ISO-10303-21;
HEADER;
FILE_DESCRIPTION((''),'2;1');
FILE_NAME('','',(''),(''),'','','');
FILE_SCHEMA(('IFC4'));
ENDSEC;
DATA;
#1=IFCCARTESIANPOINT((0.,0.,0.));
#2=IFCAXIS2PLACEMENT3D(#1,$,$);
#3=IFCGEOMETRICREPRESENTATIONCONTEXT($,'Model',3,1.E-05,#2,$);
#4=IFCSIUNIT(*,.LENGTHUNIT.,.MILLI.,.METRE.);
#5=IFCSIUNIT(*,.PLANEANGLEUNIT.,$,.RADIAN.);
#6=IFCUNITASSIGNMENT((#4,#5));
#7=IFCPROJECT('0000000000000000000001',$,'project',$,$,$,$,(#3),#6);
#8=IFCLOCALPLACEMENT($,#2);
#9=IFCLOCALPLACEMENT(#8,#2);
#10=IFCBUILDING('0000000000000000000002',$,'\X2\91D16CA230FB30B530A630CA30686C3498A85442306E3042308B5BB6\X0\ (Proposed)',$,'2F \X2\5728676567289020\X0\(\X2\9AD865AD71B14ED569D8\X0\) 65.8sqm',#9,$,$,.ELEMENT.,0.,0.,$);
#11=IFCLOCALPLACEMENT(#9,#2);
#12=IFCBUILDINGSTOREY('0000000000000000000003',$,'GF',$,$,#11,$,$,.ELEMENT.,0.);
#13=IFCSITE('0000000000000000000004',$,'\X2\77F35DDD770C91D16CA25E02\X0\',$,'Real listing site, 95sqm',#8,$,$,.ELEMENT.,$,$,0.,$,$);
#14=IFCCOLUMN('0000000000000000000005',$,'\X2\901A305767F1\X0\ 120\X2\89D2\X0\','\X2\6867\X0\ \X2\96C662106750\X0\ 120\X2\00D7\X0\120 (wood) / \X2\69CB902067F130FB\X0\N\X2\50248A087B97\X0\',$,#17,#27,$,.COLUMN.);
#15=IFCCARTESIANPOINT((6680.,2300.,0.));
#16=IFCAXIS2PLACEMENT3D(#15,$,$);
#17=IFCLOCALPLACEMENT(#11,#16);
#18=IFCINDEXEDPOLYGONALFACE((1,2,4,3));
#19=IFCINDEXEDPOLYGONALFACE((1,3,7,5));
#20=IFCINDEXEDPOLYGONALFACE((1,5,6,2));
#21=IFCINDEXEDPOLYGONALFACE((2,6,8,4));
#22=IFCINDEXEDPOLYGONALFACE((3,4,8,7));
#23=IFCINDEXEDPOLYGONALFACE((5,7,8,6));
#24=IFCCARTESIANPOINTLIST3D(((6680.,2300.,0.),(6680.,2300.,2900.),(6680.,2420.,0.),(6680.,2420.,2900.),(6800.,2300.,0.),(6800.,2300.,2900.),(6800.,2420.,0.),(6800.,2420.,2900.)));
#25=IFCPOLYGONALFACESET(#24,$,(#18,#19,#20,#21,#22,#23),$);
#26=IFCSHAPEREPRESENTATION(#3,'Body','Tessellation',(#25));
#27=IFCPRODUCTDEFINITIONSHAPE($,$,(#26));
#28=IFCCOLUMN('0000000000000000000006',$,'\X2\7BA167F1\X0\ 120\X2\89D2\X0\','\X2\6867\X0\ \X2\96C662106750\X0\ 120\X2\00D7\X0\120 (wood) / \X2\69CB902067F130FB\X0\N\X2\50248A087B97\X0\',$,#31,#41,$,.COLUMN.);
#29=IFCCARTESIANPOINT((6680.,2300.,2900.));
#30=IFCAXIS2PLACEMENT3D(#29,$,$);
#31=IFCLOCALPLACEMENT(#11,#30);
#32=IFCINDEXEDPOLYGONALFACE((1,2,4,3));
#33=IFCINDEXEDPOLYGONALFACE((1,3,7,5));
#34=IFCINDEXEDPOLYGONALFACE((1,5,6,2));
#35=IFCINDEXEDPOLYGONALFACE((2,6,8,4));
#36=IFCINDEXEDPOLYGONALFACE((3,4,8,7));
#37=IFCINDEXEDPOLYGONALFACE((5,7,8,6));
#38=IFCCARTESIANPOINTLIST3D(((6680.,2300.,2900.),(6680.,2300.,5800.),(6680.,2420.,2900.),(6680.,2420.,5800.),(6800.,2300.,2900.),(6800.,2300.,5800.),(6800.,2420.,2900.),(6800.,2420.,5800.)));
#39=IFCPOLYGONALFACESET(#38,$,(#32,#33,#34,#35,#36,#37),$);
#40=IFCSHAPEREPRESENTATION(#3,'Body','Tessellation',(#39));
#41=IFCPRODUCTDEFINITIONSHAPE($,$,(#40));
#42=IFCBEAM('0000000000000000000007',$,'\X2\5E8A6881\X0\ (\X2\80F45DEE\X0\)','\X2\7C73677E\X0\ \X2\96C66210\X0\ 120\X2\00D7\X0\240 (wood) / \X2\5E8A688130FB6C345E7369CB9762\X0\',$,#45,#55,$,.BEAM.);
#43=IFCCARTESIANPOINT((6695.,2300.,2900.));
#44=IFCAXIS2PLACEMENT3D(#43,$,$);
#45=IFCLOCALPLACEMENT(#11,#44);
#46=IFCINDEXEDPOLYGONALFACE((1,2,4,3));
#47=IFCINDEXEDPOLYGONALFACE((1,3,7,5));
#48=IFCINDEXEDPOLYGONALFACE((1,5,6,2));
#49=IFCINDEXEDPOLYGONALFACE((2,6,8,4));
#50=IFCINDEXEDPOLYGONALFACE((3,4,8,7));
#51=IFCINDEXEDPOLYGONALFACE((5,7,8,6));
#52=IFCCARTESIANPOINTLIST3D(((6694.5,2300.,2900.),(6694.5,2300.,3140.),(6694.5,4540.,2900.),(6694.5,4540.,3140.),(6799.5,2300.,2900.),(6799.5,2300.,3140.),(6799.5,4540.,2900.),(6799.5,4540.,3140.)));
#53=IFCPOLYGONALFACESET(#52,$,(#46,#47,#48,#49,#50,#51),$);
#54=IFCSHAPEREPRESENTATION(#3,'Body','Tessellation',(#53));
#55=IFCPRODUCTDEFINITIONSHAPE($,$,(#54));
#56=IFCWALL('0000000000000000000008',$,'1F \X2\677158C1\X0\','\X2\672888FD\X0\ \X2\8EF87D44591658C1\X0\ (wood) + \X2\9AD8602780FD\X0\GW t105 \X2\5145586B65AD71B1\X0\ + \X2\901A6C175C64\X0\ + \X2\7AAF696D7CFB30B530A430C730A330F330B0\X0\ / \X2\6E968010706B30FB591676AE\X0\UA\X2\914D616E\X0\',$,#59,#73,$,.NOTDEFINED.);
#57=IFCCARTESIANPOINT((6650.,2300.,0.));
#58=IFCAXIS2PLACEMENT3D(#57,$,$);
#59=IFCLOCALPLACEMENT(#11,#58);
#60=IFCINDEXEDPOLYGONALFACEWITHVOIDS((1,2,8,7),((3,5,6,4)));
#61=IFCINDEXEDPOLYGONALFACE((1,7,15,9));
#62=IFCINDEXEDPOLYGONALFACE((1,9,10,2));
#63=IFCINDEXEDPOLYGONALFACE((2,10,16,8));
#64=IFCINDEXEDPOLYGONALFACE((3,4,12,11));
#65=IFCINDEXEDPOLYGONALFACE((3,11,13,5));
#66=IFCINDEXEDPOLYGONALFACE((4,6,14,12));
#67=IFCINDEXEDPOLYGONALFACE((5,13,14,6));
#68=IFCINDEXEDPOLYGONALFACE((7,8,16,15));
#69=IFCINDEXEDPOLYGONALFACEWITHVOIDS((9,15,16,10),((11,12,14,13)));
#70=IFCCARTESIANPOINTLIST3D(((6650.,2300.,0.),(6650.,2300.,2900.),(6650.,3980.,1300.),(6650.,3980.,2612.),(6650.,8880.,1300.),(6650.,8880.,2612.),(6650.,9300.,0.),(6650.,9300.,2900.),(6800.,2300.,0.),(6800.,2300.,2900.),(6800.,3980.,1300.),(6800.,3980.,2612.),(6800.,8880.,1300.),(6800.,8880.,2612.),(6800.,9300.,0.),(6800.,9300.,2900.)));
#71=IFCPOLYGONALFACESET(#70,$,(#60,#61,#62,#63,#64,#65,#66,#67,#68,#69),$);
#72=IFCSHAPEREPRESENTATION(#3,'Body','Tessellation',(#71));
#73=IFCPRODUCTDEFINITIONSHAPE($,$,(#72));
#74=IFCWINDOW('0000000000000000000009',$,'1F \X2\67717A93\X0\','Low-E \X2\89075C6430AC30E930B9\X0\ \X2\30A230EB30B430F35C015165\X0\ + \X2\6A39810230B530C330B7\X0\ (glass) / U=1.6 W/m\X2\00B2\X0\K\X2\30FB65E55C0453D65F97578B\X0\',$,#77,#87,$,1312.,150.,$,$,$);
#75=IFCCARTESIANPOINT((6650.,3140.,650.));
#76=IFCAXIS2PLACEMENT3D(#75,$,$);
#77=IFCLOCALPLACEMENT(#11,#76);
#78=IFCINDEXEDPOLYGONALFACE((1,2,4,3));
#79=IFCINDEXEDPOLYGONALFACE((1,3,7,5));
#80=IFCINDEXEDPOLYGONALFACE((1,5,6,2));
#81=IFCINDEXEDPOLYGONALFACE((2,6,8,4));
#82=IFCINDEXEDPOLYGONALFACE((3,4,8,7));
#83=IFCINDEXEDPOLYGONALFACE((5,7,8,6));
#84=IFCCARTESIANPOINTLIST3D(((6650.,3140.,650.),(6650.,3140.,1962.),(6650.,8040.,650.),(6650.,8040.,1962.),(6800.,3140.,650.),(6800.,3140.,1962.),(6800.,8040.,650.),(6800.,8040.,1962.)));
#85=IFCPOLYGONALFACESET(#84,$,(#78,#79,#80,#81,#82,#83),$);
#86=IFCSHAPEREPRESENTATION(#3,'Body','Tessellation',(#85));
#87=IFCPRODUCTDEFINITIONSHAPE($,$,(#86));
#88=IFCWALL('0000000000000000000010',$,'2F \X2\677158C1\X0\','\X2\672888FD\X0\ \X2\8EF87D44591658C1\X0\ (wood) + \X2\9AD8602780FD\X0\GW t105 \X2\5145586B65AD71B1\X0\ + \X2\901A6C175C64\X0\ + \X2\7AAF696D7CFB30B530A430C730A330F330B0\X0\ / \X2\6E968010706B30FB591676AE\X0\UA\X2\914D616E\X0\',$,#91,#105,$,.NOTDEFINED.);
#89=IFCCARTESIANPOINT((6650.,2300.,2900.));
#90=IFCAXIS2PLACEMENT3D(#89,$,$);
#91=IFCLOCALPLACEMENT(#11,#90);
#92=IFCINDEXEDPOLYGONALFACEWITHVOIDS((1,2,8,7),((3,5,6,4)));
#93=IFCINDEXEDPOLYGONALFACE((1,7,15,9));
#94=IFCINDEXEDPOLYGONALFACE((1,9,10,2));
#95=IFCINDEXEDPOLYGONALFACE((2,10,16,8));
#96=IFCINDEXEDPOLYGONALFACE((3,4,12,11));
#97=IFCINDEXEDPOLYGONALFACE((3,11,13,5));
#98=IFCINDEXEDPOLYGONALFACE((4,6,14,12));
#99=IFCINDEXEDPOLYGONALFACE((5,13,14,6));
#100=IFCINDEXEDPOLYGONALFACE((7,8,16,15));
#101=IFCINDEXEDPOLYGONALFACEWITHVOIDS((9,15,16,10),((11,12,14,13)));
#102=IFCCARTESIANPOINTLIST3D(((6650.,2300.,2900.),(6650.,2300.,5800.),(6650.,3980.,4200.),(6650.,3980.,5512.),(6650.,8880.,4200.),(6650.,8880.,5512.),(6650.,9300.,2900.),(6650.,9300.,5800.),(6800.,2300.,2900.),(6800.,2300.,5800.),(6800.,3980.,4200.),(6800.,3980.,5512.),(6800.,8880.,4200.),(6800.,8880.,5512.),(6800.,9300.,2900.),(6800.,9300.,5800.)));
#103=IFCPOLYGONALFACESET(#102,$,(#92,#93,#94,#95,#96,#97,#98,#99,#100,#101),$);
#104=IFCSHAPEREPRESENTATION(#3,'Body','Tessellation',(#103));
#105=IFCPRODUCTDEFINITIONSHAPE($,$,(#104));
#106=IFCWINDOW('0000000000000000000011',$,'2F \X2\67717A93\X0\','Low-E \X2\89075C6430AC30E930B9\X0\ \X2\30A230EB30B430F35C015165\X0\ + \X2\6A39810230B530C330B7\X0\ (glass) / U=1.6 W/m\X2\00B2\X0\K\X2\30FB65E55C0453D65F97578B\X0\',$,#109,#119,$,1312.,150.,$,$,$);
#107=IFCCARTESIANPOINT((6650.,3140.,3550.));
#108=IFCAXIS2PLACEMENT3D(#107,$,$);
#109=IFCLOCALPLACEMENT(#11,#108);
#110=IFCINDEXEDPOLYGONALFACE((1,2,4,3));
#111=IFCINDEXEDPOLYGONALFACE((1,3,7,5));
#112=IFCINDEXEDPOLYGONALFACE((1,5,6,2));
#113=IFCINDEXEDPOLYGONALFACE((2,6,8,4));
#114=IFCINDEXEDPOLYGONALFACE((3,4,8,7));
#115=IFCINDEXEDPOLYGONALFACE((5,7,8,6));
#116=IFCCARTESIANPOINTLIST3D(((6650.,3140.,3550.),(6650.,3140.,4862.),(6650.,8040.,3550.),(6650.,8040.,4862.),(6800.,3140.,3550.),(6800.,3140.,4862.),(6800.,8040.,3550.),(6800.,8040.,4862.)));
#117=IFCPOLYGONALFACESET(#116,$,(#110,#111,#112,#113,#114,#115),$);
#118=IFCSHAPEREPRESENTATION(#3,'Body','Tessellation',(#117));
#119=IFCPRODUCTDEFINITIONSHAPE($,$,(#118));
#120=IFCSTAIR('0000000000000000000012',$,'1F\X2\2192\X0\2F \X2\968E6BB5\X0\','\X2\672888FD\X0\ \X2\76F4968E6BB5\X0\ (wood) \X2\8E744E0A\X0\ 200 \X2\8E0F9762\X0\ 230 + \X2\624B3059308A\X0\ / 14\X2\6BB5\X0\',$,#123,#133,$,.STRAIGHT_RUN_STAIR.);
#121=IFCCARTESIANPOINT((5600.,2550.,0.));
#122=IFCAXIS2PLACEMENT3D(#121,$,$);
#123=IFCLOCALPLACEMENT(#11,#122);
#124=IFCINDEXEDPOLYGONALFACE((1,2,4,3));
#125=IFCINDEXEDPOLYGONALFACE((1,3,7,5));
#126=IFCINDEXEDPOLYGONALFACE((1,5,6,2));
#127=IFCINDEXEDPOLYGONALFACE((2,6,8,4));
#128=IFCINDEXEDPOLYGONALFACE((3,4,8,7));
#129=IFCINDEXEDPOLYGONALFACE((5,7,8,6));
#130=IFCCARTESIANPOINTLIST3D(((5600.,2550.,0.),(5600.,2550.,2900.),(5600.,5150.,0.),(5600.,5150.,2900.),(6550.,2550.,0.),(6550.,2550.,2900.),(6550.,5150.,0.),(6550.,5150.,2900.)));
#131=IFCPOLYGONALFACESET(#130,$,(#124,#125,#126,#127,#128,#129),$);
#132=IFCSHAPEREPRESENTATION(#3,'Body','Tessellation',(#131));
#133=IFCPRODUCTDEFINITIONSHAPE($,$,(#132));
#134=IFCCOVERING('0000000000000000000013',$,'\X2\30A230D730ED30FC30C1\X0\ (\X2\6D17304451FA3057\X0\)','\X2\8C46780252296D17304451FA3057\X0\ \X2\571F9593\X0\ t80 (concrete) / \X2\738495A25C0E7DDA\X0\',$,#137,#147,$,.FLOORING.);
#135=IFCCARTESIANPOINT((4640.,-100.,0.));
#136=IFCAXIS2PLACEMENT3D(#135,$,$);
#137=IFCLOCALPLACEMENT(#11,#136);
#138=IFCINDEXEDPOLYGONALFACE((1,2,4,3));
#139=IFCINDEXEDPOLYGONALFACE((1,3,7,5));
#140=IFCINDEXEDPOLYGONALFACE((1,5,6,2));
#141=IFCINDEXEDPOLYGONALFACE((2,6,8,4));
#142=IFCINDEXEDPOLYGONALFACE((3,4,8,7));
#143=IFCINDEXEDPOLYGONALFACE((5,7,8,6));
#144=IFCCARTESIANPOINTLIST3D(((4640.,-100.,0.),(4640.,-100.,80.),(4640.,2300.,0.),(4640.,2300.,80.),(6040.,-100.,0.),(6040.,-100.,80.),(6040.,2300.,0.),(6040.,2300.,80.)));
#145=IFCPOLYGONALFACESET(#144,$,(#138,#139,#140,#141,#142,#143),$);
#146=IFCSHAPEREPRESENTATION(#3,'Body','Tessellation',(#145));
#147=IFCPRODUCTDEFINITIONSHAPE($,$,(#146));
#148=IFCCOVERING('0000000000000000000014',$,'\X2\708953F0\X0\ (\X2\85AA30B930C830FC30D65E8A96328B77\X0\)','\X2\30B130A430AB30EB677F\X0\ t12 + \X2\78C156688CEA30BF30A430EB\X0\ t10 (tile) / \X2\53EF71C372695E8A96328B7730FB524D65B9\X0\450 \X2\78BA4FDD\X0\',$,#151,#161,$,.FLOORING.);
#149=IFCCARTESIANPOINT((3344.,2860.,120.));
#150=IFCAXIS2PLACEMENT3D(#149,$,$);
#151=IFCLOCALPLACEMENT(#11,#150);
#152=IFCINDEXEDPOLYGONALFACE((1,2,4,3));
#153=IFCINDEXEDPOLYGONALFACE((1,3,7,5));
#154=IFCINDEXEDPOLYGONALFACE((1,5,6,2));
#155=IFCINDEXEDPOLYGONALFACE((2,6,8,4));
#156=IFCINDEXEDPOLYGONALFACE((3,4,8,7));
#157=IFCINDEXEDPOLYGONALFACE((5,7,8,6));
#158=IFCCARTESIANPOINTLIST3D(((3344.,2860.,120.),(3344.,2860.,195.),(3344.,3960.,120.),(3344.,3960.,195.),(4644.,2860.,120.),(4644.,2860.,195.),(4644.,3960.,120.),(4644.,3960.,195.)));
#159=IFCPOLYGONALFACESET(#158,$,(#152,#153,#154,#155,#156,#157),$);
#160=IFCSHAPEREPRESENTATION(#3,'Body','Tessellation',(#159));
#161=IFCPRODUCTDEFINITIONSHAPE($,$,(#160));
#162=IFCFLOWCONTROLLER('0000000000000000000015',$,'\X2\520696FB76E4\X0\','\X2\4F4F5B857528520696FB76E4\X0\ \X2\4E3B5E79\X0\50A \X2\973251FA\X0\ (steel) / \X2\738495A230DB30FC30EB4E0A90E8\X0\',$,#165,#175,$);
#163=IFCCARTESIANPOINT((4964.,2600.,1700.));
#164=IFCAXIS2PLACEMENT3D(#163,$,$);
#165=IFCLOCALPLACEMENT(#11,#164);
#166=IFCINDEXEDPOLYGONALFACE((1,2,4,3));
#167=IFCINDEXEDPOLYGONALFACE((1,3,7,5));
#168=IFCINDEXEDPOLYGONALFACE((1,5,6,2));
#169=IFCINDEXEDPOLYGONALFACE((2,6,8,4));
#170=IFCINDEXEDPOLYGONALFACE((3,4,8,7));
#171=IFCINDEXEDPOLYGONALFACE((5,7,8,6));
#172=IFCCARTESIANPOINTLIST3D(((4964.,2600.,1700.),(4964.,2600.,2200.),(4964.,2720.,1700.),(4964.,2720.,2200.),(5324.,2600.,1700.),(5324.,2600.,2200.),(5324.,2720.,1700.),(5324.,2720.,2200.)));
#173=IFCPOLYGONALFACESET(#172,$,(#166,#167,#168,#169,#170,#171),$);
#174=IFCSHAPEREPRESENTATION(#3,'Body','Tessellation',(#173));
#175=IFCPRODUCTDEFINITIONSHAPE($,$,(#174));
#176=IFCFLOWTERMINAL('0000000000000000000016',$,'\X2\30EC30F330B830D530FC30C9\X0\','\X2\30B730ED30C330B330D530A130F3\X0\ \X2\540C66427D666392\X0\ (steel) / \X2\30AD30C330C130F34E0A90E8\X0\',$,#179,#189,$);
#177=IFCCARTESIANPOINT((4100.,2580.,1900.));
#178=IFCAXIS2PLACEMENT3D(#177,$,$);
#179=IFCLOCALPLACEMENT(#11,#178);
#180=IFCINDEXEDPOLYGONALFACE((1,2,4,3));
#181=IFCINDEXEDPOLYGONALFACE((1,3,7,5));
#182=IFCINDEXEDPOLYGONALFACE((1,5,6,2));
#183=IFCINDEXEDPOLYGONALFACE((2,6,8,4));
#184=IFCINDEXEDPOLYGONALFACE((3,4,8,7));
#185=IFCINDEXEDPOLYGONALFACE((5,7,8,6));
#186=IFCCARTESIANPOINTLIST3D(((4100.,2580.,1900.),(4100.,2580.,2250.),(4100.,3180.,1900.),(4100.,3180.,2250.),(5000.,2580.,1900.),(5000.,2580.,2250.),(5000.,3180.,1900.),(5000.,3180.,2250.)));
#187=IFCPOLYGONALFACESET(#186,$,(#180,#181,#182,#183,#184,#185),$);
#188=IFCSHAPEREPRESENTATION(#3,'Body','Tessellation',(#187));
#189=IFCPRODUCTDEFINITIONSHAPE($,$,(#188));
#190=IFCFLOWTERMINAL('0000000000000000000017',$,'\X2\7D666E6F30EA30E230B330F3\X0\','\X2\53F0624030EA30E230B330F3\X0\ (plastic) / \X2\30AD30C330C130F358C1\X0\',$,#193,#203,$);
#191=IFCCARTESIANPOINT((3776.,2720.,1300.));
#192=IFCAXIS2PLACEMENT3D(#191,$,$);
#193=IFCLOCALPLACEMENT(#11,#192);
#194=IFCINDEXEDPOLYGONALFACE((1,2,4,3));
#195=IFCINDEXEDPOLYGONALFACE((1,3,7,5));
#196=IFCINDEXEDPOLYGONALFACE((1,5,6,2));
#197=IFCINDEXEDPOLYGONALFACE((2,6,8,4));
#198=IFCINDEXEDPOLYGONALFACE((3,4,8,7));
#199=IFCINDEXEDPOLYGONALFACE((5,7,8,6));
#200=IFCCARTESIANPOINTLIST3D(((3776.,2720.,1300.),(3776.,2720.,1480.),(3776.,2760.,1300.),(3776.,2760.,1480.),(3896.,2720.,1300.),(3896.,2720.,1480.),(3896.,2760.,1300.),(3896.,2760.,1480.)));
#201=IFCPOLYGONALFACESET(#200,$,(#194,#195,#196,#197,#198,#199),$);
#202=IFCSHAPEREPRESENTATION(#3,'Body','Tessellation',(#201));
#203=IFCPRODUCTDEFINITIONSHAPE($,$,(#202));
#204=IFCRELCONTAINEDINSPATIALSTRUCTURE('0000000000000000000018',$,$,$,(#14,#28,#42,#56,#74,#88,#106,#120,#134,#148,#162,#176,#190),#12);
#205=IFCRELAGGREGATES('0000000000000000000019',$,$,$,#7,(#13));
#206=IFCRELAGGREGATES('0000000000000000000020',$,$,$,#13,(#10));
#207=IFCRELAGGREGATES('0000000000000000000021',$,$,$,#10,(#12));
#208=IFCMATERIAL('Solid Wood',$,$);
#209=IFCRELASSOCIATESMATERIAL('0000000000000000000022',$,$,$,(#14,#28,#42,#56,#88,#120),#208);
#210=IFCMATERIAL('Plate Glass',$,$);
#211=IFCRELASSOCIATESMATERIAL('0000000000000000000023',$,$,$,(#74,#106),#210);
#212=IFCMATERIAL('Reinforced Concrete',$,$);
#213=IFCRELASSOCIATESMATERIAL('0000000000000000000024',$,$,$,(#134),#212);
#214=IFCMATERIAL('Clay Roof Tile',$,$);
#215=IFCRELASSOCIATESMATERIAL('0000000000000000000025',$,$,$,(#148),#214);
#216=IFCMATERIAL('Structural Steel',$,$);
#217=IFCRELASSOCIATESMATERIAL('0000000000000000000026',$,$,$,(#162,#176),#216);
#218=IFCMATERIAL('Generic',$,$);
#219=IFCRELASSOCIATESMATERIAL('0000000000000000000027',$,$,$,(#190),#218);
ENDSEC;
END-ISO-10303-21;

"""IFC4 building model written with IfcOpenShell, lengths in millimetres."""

from ifc_helpers import new_model, si_unit, frame, frame_2d, origin, place, context, project, spatial, rectangle, extrude, material, element, fill, save


model = new_model("IFC4")

# Units and contexts
model_context = context("Model", 3, precision=1e-05, world=origin())
ifc_project = project(units=[si_unit("LENGTHUNIT", "METRE", prefix="MILLI"), si_unit("PLANEANGLEUNIT", "RADIAN")], contexts=[model_context])

# Site, building, storey
site_placement = place(None, origin())
site = spatial("IfcSite", under=ifc_project, at=site_placement, Name="石川県金沢市", ObjectType="Real listing site, 95sqm", CompositionType="ELEMENT", RefElevation=0.0)
building_placement = place(site_placement, origin())
building = spatial("IfcBuilding", under=site, at=building_placement, Name="金沢・サウナと水風呂のある家 (Proposed)", ObjectType="2F 在来木造(高断熱仕様) 65.8sqm", CompositionType="ELEMENT", ElevationOfRefHeight=0.0, ElevationOfTerrain=0.0)
storey_placement = place(building_placement, origin())
storey = spatial("IfcBuildingStorey", under=building, at=storey_placement, Name="GF", CompositionType="ELEMENT", Elevation=0.0)

# Columns
ifc_material_1 = material(Name="Solid Wood")
column_1_placement = place(storey_placement, frame((6680.0, 2300.0, 0.0)))
element("IfcColumn", 1, at=column_1_placement, inside=storey, material=ifc_material_1, Name="通し柱 120角", Description="桧 集成材 120×120 (wood) / 構造柱・N値計算", PredefinedType="COLUMN", context=model_context, shape_type="SweptSolid", body=[
    extrude(rectangle(XDim=120.0, YDim=120.0, at=frame_2d((60.0, 60.0))), frame((6680.0, 2300.0, 0.0)), (0.0, 0.0, 1.0), 2900.0),
])
column_2_placement = place(storey_placement, frame((6680.0, 2300.0, 2900.0)))
element("IfcColumn", 2, at=column_2_placement, inside=storey, material=ifc_material_1, Name="管柱 120角", Description="桧 集成材 120×120 (wood) / 構造柱・N値計算", PredefinedType="COLUMN", context=model_context, shape_type="SweptSolid", body=[
    extrude(rectangle(XDim=120.0, YDim=120.0, at=frame_2d((60.0, 60.0))), frame((6680.0, 2300.0, 2900.0)), (0.0, 0.0, 1.0), 2900.0),
])

# Beam
beam_1_placement = place(storey_placement, frame((6695.0, 2300.0, 2900.0)))
element("IfcBeam", 3, at=beam_1_placement, inside=storey, material=ifc_material_1, Name="床梁 (胴差)", Description="米松 集成 120×240 (wood) / 床梁・水平構面", PredefinedType="BEAM", context=model_context, shape_type="SweptSolid", body=[
    extrude(rectangle(XDim=105.0, YDim=2240.0, at=frame_2d((52.0, 1120.0))), frame((6695.0, 2300.0, 2900.0)), (0.0, 0.0, 1.0), 240.0),
])

# Wall, opening, window
wall_1_placement = place(storey_placement, frame((6650.0, 2300.0, 0.0)))
wall_1 = element("IfcWall", 4, at=wall_1_placement, inside=storey, material=ifc_material_1, Name="1F 東壁", Description="木製 軸組外壁 (wood) + 高性能GW t105 充填断熱 + 通気層 + 窯業系サイディング / 準耐火・外皮UA配慮", PredefinedType="NOTDEFINED", context=model_context, shape_type="SweptSolid", body=[
    extrude(rectangle(XDim=150.0, YDim=7000.0, at=frame_2d((75.0, 3500.0))), frame((6650.0, 2300.0, 0.0)), (0.0, 0.0, 1.0), 2900.0),
])
opening_1_placement = place(storey_placement, frame((6650.0, 3140.0, 650.0)))
opening_1 = element("IfcOpeningElement", 5, at=opening_1_placement, cuts=wall_1, PredefinedType="NOTDEFINED", context=model_context, shape_type="SweptSolid", body=[
    extrude(rectangle(XDim=150.0, YDim=4900.0, at=frame_2d((75.0, 2450.0))), frame((6650.0, 3140.0, 650.0)), (0.0, 0.0, 1.0), 1312.0),
])
ifc_material_2 = material(Name="Plate Glass")
window_1_placement = place(storey_placement, frame((6650.0, 3140.0, 650.0)))
window_1 = element("IfcWindow", 6, at=window_1_placement, inside=storey, material=ifc_material_2, Name="1F 東窓", Description="Low-E 複層ガラス アルゴン封入 + 樹脂サッシ (glass) / U=1.6 W/m²K・日射取得型", OverallHeight=1312.0, OverallWidth=150.0, context=model_context, shape_type="SweptSolid", body=[
    extrude(rectangle(XDim=150.0, YDim=4900.0, at=frame_2d((75.0, 2450.0))), frame((6650.0, 3140.0, 650.0)), (0.0, 0.0, 1.0), 1312.0),
])
fill(opening_1, window_1)

# Wall, opening, window
wall_2_placement = place(storey_placement, frame((6650.0, 2300.0, 2900.0)))
wall_2 = element("IfcWall", 7, at=wall_2_placement, inside=storey, material=ifc_material_1, Name="2F 東壁", Description="木製 軸組外壁 (wood) + 高性能GW t105 充填断熱 + 通気層 + 窯業系サイディング / 準耐火・外皮UA配慮", PredefinedType="NOTDEFINED", context=model_context, shape_type="SweptSolid", body=[
    extrude(rectangle(XDim=150.0, YDim=7000.0, at=frame_2d((75.0, 3500.0))), frame((6650.0, 2300.0, 2900.0)), (0.0, 0.0, 1.0), 2900.0),
])
opening_2_placement = place(storey_placement, frame((6650.0, 3140.0, 3550.0)))
opening_2 = element("IfcOpeningElement", 8, at=opening_2_placement, cuts=wall_2, PredefinedType="NOTDEFINED", context=model_context, shape_type="SweptSolid", body=[
    extrude(rectangle(XDim=150.0, YDim=4900.0, at=frame_2d((75.0, 2450.0))), frame((6650.0, 3140.0, 3550.0)), (0.0, 0.0, 1.0), 1312.0),
])
window_2_placement = place(storey_placement, frame((6650.0, 3140.0, 3550.0)))
window_2 = element("IfcWindow", 9, at=window_2_placement, inside=storey, material=ifc_material_2, Name="2F 東窓", Description="Low-E 複層ガラス アルゴン封入 + 樹脂サッシ (glass) / U=1.6 W/m²K・日射取得型", OverallHeight=1312.0, OverallWidth=150.0, context=model_context, shape_type="SweptSolid", body=[
    extrude(rectangle(XDim=150.0, YDim=4900.0, at=frame_2d((75.0, 2450.0))), frame((6650.0, 3140.0, 3550.0)), (0.0, 0.0, 1.0), 1312.0),
])
fill(opening_2, window_2)

# Stair
stair_placement = place(storey_placement, frame((5600.0, 2550.0, 0.0)))
element("IfcStair", 10, at=stair_placement, inside=storey, material=ifc_material_1, Name="1F→2F 階段", Description="木製 直階段 (wood) 蹴上 200 踏面 230 + 手すり / 14段", PredefinedType="STRAIGHT_RUN_STAIR", context=model_context, shape_type="SweptSolid", body=[
    extrude(rectangle(XDim=950.0, YDim=2600.0, at=frame_2d((475.0, 1300.0))), frame((5600.0, 2550.0, 0.0)), (0.0, 0.0, 1.0), 2900.0),
])

# Coverings
ifc_material_3 = material(Name="Reinforced Concrete")
covering_1_placement = place(storey_placement, frame((4640.0, -100.0, 0.0)))
element("IfcCovering", 11, at=covering_1_placement, inside=storey, material=ifc_material_3, Name="アプローチ (洗い出し)", Description="豆砂利洗い出し 土間 t80 (concrete) / 玄関導線", PredefinedType="FLOORING", context=model_context, shape_type="SweptSolid", body=[
    extrude(rectangle(XDim=1400.0, YDim=2400.0, at=frame_2d((700.0, 1200.0))), frame((4640.0, -100.0, 0.0)), (0.0, 0.0, 1.0), 80.0),
])
ifc_material_4 = material(Name="Clay Roof Tile")
covering_2_placement = place(storey_placement, frame((3344.0, 2860.0, 120.0)))
element("IfcCovering", 12, at=covering_2_placement, inside=storey, material=ifc_material_4, Name="炉台 (薪ストーブ床防護)", Description="ケイカル板 t12 + 磁器質タイル t10 (tile) / 可燃物床防護・前方450 確保", PredefinedType="FLOORING", context=model_context, shape_type="SweptSolid", body=[
    extrude(rectangle(XDim=1300.0, YDim=1100.0, at=frame_2d((650.0, 550.0))), frame((3344.0, 2860.0, 120.0)), (0.0, 0.0, 1.0), 75.0),
])

# Flow controller
ifc_material_5 = material(Name="Structural Steel")
flow_controller_placement = place(storey_placement, frame((4964.0, 2600.0, 1700.0)))
element("IfcFlowController", 13, at=flow_controller_placement, inside=storey, material=ifc_material_5, Name="分電盤", Description="住宅用分電盤 主幹50A 露出 (steel) / 玄関ホール上部", context=model_context, shape_type="SweptSolid", body=[
    extrude(rectangle(XDim=360.0, YDim=120.0, at=frame_2d((180.0, 60.0))), frame((4964.0, 2600.0, 1700.0)), (0.0, 0.0, 1.0), 500.0),
])

# Flow terminals
flow_terminal_1_placement = place(storey_placement, frame((4100.0, 2580.0, 1900.0)))
element("IfcFlowTerminal", 14, at=flow_terminal_1_placement, inside=storey, material=ifc_material_5, Name="レンジフード", Description="シロッコファン 同時給排 (steel) / キッチン上部", context=model_context, shape_type="SweptSolid", body=[
    extrude(rectangle(XDim=900.0, YDim=600.0, at=frame_2d((450.0, 300.0))), frame((4100.0, 2580.0, 1900.0)), (0.0, 0.0, 1.0), 350.0),
])
ifc_material_6 = material(Name="Generic")
flow_terminal_2_placement = place(storey_placement, frame((3776.0, 2720.0, 1300.0)))
element("IfcFlowTerminal", 15, at=flow_terminal_2_placement, inside=storey, material=ifc_material_6, Name="給湯リモコン", Description="台所リモコン (plastic) / キッチン壁", context=model_context, shape_type="SweptSolid", body=[
    extrude(rectangle(XDim=120.0, YDim=40.0, at=frame_2d((60.0, 20.0))), frame((3776.0, 2720.0, 1300.0)), (0.0, 0.0, 1.0), 180.0),
])

save(model, "model.ifc")
